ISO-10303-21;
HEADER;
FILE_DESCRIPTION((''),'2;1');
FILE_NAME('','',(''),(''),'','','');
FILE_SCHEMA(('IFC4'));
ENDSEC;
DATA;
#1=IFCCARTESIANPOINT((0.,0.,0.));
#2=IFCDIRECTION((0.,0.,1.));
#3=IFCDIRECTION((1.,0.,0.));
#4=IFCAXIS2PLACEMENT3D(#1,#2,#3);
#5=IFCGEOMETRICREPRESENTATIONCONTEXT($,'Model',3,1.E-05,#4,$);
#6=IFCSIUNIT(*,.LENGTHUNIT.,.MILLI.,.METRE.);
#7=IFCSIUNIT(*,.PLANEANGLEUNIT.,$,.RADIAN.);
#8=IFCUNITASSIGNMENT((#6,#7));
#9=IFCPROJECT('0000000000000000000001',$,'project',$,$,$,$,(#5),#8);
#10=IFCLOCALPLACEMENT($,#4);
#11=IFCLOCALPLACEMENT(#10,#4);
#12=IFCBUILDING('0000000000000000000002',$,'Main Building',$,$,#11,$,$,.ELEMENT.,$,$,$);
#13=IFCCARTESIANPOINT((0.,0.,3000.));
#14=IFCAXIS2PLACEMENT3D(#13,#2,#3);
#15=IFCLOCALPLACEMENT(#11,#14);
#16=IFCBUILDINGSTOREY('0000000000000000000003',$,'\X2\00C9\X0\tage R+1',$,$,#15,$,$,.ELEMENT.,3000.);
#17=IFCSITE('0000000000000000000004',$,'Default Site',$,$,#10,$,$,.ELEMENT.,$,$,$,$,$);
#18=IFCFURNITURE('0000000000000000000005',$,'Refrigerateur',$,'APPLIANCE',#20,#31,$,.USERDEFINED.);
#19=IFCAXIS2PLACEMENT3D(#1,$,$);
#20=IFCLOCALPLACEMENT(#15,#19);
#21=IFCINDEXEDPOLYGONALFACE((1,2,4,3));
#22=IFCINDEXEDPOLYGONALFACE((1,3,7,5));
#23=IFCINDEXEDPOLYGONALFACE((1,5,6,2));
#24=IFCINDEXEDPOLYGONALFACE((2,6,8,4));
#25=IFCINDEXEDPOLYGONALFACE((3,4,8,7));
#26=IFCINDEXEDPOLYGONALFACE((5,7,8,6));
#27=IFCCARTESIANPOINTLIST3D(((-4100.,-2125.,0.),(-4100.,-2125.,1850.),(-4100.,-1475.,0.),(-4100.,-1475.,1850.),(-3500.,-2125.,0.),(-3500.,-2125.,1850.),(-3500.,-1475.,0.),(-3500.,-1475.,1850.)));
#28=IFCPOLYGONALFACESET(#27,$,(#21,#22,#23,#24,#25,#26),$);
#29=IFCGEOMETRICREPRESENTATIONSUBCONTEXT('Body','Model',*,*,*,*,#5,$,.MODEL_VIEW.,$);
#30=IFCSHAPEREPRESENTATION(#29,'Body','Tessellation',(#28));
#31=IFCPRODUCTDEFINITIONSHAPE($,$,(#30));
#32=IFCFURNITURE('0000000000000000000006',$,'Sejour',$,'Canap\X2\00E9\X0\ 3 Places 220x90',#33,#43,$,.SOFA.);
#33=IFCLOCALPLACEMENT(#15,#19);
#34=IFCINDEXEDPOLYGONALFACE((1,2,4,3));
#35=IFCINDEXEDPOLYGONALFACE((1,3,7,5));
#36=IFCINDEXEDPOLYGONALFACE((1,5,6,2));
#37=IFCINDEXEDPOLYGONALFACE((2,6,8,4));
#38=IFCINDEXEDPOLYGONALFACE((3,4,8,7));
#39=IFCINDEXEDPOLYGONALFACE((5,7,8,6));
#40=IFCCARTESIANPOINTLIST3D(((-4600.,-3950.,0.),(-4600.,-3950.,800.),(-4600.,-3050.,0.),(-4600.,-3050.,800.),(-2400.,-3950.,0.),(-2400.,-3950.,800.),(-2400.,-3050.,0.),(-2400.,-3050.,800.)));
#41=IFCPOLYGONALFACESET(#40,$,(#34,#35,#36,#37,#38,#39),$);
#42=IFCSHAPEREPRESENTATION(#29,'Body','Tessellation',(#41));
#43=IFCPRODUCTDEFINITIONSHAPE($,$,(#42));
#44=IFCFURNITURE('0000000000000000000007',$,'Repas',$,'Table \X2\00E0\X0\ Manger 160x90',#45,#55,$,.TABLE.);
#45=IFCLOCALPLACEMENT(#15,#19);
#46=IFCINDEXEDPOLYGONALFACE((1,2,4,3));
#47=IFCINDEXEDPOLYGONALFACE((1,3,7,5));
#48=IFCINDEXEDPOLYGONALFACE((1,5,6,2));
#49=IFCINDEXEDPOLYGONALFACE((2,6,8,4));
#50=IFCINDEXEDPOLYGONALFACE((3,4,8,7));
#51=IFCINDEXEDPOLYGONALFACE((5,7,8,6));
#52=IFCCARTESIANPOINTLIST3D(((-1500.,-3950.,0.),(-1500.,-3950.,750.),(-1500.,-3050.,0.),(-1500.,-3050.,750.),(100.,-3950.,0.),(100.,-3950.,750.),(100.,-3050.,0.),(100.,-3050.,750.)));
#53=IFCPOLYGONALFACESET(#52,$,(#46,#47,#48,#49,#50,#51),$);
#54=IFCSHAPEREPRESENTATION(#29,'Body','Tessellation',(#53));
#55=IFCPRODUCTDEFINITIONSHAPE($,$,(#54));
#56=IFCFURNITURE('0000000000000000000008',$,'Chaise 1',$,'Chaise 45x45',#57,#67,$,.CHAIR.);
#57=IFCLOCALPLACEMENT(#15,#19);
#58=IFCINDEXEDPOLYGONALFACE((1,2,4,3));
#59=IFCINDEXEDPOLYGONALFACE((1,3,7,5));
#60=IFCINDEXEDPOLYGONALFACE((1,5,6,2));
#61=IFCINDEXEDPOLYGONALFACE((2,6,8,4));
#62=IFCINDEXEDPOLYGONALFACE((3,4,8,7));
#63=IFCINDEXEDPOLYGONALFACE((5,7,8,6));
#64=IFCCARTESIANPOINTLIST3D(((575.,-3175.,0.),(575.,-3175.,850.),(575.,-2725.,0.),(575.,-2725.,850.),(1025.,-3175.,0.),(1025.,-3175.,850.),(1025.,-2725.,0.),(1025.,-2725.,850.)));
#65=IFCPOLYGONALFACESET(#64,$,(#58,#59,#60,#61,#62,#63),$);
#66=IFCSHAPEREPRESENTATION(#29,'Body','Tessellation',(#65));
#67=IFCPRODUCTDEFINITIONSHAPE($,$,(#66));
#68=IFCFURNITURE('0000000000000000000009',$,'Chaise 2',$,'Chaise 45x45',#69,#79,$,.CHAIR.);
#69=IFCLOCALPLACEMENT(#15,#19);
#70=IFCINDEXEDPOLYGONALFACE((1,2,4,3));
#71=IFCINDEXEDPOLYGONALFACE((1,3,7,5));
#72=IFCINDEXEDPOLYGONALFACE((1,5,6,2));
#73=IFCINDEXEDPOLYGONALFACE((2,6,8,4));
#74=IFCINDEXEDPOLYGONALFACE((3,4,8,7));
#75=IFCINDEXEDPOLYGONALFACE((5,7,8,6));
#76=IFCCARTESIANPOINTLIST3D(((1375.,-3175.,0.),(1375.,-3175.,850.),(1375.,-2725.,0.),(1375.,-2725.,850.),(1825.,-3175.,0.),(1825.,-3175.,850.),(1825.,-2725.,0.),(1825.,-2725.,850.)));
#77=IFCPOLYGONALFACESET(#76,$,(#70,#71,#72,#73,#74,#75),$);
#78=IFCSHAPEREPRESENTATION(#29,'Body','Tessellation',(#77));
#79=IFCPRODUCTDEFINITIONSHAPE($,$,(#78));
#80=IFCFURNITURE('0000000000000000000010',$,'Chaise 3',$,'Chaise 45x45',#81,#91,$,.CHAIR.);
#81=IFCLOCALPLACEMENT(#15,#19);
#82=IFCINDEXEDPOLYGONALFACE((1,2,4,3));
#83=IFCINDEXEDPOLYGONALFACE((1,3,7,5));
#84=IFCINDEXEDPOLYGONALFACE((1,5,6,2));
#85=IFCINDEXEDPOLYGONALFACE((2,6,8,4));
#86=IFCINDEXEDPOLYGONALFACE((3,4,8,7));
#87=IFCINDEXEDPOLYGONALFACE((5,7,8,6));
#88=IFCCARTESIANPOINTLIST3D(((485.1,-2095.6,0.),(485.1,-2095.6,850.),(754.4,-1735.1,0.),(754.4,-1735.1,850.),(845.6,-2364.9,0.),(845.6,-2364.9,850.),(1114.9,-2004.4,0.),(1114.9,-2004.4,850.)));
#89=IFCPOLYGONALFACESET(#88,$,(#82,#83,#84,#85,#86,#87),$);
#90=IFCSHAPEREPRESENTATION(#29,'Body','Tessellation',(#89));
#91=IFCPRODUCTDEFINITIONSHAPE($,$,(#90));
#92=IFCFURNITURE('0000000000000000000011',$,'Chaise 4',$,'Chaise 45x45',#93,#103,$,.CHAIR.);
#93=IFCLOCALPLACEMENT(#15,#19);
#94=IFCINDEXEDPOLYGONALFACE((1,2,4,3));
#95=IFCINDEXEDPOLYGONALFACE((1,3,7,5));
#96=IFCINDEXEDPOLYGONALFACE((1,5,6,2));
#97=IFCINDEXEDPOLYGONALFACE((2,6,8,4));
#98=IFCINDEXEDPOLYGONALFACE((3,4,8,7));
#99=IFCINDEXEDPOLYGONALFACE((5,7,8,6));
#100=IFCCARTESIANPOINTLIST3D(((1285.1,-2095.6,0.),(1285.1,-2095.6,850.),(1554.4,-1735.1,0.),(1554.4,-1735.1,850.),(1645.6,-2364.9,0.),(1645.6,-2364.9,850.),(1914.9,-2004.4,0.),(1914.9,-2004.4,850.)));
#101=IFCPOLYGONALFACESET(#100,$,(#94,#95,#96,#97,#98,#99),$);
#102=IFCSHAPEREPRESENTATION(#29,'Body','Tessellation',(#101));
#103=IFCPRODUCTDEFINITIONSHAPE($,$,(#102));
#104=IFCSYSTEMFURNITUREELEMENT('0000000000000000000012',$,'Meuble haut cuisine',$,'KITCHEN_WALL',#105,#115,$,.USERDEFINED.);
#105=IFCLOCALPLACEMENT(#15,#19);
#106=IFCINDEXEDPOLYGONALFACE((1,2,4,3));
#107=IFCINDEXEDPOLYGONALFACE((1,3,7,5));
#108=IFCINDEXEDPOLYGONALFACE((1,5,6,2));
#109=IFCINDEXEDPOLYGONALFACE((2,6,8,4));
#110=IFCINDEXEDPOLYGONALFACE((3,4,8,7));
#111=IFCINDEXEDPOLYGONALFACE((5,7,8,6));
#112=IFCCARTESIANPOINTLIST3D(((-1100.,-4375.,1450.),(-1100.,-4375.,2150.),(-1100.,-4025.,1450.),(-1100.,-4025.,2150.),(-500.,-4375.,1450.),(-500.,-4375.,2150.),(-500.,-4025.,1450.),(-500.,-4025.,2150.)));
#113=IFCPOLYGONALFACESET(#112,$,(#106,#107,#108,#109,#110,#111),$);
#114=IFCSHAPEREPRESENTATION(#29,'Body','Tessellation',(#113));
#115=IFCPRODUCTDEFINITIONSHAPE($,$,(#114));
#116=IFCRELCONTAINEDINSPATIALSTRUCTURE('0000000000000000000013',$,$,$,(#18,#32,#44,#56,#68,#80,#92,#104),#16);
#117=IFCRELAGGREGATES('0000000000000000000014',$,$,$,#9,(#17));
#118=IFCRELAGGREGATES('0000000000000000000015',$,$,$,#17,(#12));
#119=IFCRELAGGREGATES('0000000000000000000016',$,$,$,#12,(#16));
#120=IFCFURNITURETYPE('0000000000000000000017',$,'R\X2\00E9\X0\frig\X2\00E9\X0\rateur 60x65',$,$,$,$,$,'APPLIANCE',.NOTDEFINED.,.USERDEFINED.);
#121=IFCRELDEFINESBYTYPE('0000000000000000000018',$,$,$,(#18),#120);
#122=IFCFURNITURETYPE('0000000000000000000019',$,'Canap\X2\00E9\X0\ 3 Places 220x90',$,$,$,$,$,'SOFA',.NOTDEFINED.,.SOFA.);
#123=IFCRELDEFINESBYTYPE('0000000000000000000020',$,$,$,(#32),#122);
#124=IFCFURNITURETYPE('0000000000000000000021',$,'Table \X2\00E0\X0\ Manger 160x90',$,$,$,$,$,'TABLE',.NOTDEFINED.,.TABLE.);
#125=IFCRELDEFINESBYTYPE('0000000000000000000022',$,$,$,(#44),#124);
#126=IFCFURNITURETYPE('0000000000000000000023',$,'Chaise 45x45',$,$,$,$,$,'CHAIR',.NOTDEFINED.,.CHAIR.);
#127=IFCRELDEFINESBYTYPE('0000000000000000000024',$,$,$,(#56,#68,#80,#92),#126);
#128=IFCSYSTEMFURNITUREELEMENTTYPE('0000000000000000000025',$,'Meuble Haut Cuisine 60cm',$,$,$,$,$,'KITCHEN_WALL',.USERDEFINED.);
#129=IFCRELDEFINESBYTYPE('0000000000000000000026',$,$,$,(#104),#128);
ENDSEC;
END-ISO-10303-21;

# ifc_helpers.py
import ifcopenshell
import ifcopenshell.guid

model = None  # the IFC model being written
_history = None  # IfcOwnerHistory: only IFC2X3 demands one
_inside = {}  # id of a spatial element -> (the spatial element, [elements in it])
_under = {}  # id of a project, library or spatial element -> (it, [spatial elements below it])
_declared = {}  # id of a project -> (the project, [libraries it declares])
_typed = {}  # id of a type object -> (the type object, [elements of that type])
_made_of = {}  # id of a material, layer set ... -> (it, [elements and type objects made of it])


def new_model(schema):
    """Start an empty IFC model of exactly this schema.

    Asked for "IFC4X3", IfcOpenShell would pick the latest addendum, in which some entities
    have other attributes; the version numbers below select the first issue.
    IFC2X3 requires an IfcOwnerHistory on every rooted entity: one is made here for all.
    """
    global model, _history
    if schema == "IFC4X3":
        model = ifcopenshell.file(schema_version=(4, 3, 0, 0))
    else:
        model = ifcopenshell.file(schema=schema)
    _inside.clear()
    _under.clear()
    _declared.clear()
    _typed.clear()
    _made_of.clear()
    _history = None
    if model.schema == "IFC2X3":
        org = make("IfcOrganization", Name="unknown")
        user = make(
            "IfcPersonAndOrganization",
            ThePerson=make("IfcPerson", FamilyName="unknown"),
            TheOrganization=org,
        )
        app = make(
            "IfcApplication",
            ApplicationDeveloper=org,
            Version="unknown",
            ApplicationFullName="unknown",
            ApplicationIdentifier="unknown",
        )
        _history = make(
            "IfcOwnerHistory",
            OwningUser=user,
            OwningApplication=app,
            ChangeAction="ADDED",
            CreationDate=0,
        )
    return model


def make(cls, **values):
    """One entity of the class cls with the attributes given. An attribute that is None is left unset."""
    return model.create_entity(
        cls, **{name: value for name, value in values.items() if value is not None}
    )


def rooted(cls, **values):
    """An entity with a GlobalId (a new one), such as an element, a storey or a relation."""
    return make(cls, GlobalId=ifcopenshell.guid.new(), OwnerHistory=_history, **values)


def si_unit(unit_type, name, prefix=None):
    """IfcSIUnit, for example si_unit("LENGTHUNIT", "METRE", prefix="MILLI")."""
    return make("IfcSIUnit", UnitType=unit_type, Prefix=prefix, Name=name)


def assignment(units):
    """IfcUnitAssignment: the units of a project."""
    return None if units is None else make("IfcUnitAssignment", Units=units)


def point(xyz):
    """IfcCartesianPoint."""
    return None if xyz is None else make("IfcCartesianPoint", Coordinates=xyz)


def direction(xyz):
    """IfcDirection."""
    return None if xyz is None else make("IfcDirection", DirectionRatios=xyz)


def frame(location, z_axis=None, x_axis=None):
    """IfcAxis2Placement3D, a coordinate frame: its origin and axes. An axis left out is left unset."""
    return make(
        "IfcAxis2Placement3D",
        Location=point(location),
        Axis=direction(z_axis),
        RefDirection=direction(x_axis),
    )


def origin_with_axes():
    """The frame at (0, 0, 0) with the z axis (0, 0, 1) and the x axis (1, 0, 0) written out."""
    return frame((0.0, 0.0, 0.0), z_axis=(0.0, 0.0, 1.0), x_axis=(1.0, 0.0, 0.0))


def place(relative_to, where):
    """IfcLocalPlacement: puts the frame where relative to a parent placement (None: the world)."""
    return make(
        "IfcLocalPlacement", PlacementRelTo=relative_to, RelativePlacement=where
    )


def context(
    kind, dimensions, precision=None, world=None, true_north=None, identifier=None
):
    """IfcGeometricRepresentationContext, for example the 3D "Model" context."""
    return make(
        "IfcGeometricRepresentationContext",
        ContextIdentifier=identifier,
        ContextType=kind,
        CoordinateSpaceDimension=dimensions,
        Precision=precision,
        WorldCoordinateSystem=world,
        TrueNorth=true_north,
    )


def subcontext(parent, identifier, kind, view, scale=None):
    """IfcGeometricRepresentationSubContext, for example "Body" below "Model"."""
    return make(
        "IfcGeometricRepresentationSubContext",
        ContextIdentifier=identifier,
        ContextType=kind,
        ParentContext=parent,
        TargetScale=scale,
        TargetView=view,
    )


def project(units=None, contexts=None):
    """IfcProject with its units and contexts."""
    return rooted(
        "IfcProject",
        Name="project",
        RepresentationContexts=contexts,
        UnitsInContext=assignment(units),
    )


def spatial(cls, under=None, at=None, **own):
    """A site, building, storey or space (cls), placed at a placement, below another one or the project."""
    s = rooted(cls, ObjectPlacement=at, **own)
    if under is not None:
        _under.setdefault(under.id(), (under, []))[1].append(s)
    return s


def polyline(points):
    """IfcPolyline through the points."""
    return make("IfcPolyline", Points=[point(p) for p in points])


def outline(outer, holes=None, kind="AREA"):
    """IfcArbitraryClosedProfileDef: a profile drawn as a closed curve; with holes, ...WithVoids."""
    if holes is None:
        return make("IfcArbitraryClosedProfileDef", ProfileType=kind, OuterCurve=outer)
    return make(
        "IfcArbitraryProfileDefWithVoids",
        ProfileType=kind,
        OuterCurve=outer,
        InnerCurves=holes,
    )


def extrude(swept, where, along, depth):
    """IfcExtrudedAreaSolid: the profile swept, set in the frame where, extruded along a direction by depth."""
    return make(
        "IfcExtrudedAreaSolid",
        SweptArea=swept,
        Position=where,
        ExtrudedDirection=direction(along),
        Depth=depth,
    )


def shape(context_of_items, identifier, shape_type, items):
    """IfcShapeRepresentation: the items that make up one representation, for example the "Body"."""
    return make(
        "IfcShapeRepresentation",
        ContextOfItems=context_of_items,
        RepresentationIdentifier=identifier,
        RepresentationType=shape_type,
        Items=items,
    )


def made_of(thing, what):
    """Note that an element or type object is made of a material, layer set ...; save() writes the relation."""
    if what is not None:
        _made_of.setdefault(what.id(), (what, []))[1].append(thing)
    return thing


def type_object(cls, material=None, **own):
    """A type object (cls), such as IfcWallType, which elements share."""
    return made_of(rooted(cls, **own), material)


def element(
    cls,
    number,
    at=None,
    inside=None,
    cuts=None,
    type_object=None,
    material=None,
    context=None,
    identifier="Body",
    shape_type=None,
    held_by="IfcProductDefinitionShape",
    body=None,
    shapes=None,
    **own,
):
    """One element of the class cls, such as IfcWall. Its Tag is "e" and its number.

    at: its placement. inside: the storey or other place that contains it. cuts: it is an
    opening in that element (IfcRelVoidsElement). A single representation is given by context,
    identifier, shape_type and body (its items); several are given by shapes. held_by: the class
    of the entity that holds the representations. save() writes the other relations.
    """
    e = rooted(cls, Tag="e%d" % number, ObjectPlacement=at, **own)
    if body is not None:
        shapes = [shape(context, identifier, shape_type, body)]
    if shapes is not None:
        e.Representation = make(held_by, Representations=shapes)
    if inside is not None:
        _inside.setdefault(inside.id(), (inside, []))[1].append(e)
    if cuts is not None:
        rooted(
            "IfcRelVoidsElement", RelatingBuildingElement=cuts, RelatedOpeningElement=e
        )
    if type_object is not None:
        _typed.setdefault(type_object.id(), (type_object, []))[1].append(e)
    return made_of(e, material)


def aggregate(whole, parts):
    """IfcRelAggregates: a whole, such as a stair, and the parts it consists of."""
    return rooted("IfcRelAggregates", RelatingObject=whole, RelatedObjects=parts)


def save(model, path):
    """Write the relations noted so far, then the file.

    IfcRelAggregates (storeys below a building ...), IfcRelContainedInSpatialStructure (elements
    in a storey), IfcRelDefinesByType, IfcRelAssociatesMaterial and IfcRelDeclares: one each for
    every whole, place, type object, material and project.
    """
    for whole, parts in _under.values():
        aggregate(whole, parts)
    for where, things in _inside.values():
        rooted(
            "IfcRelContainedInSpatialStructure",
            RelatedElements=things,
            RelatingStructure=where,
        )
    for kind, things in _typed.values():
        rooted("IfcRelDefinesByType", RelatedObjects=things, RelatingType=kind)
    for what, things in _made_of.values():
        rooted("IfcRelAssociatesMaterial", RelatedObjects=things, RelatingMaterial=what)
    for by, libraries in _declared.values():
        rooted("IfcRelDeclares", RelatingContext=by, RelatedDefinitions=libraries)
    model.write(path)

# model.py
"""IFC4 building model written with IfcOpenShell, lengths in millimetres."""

from ifc_helpers import new_model, si_unit, frame, origin_with_axes, place, context, subcontext, project, spatial, polyline, outline, extrude, type_object, element, save


model = new_model("IFC4")

# Units and contexts
model_context = context("Model", 3, precision=1e-05, world=origin_with_axes())
body_context = subcontext(model_context, "Body", "Model", "MODEL_VIEW")
ifc_project = project(units=[si_unit("LENGTHUNIT", "METRE", prefix="MILLI"), si_unit("PLANEANGLEUNIT", "RADIAN")], contexts=[model_context])

# Site, building, storey
site_placement = place(None, origin_with_axes())
site = spatial("IfcSite", under=ifc_project, at=site_placement, Name="Default Site", CompositionType="ELEMENT")
building_placement = place(site_placement, origin_with_axes())
building = spatial("IfcBuilding", under=site, at=building_placement, Name="Main Building", CompositionType="ELEMENT")
storey_placement = place(building_placement, frame((0.0, 0.0, 3000.0), z_axis=(0.0, 0.0, 1.0), x_axis=(1.0, 0.0, 0.0)))
storey = spatial("IfcBuildingStorey", under=building, at=storey_placement, Name="Étage R+1", CompositionType="ELEMENT", Elevation=3000.0)

# Furniture
furniture_type_1 = type_object("IfcFurnitureType", Name="Réfrigérateur 60x65", ElementType="APPLIANCE", AssemblyPlace="NOTDEFINED", PredefinedType="USERDEFINED")
furniture_1_placement = place(storey_placement, frame((-3800.0, -1800.0, 0.0), z_axis=(0.0, 0.0, 1.0), x_axis=(1.0, 0.0, 0.0)))
element("IfcFurniture", 1, at=furniture_1_placement, inside=storey, type_object=furniture_type_1, Name="Refrigerateur", ObjectType="APPLIANCE", PredefinedType="USERDEFINED", context=body_context, shape_type="SweptSolid", body=[
    extrude(outline(polyline([(-300.0, -325.0), (300.0, -325.0), (300.0, 325.0), (-300.0, 325.0), (-300.0, -325.0)])), origin_with_axes(), (0.0, 0.0, 1.0), 1850.0),
])
furniture_type_2 = type_object("IfcFurnitureType", Name="Canapé 3 Places 220x90", ElementType="SOFA", AssemblyPlace="NOTDEFINED", PredefinedType="SOFA")
furniture_2_placement = place(storey_placement, frame((-3500.0, -3500.0, 0.0), z_axis=(0.0, 0.0, 1.0), x_axis=(1.0, 0.0, 0.0)))
element("IfcFurniture", 2, at=furniture_2_placement, inside=storey, type_object=furniture_type_2, Name="Sejour", ObjectType="Canapé 3 Places 220x90", PredefinedType="SOFA", context=body_context, shape_type="SweptSolid", body=[
    extrude(outline(polyline([(-1100.0, -450.0), (1100.0, -450.0), (1100.0, 450.0), (-1100.0, 450.0), (-1100.0, -450.0)])), origin_with_axes(), (0.0, 0.0, 1.0), 800.0),
])
furniture_type_3 = type_object("IfcFurnitureType", Name="Table à Manger 160x90", ElementType="TABLE", AssemblyPlace="NOTDEFINED", PredefinedType="TABLE")
furniture_3_placement = place(storey_placement, frame((-700.0, -3500.0, 0.0), z_axis=(0.0, 0.0, 1.0), x_axis=(1.0, 0.0, 0.0)))
element("IfcFurniture", 3, at=furniture_3_placement, inside=storey, type_object=furniture_type_3, Name="Repas", ObjectType="Table à Manger 160x90", PredefinedType="TABLE", context=body_context, shape_type="SweptSolid", body=[
    extrude(outline(polyline([(-800.0, -450.0), (800.0, -450.0), (800.0, 450.0), (-800.0, 450.0), (-800.0, -450.0)])), origin_with_axes(), (0.0, 0.0, 1.0), 750.0),
])
furniture_type_4 = type_object("IfcFurnitureType", Name="Chaise 45x45", ElementType="CHAIR", AssemblyPlace="NOTDEFINED", PredefinedType="CHAIR")
for number, where, z_axis, x_axis, name in (
    (4, (800.0, -2950.0, 0.0), (0.0, 0.0, 1.0), (1.0, 0.0, 0.0), "Chaise 1"),
    (5, (1600.0, -2950.0, 0.0), (0.0, 0.0, 1.0), (1.0, 0.0, 0.0), "Chaise 2"),
    (6, (800.0, -2050.0, 0.0), (0.0, 0.0, 1.0), (-0.59846, -0.801153, 0.0), "Chaise 3"),
    (7, (1600.0, -2050.0, 0.0), (0.0, 0.0, 1.0), (-0.59846, -0.801153, 0.0), "Chaise 4"),
):
    element("IfcFurniture", number, at=place(storey_placement, frame(where, z_axis=z_axis, x_axis=x_axis)), inside=storey, type_object=furniture_type_4, Name=name, ObjectType="Chaise 45x45", PredefinedType="CHAIR", context=body_context, shape_type="SweptSolid", body=[
        extrude(outline(polyline([(-225.0, -225.0), (225.0, -225.0), (225.0, 225.0), (-225.0, 225.0), (-225.0, -225.0)])), origin_with_axes(), (0.0, 0.0, 1.0), 850.0),
    ])

# System furniture element
system_furniture_element_type = type_object("IfcSystemFurnitureElementType", Name="Meuble Haut Cuisine 60cm", ElementType="KITCHEN_WALL", PredefinedType="USERDEFINED")
system_furniture_element_placement = place(storey_placement, frame((-800.0, -4200.0, 1450.0), z_axis=(0.0, 0.0, 1.0), x_axis=(1.0, 0.0, 0.0)))
element("IfcSystemFurnitureElement", 8, at=system_furniture_element_placement, inside=storey, type_object=system_furniture_element_type, Name="Meuble haut cuisine", ObjectType="KITCHEN_WALL", PredefinedType="USERDEFINED", context=body_context, shape_type="SweptSolid", body=[
    extrude(outline(polyline([(-300.0, -175.0), (300.0, -175.0), (300.0, 175.0), (-300.0, 175.0), (-300.0, -175.0)])), origin_with_axes(), (0.0, 0.0, 1.0), 700.0),
])

save(model, "model.ifc")
